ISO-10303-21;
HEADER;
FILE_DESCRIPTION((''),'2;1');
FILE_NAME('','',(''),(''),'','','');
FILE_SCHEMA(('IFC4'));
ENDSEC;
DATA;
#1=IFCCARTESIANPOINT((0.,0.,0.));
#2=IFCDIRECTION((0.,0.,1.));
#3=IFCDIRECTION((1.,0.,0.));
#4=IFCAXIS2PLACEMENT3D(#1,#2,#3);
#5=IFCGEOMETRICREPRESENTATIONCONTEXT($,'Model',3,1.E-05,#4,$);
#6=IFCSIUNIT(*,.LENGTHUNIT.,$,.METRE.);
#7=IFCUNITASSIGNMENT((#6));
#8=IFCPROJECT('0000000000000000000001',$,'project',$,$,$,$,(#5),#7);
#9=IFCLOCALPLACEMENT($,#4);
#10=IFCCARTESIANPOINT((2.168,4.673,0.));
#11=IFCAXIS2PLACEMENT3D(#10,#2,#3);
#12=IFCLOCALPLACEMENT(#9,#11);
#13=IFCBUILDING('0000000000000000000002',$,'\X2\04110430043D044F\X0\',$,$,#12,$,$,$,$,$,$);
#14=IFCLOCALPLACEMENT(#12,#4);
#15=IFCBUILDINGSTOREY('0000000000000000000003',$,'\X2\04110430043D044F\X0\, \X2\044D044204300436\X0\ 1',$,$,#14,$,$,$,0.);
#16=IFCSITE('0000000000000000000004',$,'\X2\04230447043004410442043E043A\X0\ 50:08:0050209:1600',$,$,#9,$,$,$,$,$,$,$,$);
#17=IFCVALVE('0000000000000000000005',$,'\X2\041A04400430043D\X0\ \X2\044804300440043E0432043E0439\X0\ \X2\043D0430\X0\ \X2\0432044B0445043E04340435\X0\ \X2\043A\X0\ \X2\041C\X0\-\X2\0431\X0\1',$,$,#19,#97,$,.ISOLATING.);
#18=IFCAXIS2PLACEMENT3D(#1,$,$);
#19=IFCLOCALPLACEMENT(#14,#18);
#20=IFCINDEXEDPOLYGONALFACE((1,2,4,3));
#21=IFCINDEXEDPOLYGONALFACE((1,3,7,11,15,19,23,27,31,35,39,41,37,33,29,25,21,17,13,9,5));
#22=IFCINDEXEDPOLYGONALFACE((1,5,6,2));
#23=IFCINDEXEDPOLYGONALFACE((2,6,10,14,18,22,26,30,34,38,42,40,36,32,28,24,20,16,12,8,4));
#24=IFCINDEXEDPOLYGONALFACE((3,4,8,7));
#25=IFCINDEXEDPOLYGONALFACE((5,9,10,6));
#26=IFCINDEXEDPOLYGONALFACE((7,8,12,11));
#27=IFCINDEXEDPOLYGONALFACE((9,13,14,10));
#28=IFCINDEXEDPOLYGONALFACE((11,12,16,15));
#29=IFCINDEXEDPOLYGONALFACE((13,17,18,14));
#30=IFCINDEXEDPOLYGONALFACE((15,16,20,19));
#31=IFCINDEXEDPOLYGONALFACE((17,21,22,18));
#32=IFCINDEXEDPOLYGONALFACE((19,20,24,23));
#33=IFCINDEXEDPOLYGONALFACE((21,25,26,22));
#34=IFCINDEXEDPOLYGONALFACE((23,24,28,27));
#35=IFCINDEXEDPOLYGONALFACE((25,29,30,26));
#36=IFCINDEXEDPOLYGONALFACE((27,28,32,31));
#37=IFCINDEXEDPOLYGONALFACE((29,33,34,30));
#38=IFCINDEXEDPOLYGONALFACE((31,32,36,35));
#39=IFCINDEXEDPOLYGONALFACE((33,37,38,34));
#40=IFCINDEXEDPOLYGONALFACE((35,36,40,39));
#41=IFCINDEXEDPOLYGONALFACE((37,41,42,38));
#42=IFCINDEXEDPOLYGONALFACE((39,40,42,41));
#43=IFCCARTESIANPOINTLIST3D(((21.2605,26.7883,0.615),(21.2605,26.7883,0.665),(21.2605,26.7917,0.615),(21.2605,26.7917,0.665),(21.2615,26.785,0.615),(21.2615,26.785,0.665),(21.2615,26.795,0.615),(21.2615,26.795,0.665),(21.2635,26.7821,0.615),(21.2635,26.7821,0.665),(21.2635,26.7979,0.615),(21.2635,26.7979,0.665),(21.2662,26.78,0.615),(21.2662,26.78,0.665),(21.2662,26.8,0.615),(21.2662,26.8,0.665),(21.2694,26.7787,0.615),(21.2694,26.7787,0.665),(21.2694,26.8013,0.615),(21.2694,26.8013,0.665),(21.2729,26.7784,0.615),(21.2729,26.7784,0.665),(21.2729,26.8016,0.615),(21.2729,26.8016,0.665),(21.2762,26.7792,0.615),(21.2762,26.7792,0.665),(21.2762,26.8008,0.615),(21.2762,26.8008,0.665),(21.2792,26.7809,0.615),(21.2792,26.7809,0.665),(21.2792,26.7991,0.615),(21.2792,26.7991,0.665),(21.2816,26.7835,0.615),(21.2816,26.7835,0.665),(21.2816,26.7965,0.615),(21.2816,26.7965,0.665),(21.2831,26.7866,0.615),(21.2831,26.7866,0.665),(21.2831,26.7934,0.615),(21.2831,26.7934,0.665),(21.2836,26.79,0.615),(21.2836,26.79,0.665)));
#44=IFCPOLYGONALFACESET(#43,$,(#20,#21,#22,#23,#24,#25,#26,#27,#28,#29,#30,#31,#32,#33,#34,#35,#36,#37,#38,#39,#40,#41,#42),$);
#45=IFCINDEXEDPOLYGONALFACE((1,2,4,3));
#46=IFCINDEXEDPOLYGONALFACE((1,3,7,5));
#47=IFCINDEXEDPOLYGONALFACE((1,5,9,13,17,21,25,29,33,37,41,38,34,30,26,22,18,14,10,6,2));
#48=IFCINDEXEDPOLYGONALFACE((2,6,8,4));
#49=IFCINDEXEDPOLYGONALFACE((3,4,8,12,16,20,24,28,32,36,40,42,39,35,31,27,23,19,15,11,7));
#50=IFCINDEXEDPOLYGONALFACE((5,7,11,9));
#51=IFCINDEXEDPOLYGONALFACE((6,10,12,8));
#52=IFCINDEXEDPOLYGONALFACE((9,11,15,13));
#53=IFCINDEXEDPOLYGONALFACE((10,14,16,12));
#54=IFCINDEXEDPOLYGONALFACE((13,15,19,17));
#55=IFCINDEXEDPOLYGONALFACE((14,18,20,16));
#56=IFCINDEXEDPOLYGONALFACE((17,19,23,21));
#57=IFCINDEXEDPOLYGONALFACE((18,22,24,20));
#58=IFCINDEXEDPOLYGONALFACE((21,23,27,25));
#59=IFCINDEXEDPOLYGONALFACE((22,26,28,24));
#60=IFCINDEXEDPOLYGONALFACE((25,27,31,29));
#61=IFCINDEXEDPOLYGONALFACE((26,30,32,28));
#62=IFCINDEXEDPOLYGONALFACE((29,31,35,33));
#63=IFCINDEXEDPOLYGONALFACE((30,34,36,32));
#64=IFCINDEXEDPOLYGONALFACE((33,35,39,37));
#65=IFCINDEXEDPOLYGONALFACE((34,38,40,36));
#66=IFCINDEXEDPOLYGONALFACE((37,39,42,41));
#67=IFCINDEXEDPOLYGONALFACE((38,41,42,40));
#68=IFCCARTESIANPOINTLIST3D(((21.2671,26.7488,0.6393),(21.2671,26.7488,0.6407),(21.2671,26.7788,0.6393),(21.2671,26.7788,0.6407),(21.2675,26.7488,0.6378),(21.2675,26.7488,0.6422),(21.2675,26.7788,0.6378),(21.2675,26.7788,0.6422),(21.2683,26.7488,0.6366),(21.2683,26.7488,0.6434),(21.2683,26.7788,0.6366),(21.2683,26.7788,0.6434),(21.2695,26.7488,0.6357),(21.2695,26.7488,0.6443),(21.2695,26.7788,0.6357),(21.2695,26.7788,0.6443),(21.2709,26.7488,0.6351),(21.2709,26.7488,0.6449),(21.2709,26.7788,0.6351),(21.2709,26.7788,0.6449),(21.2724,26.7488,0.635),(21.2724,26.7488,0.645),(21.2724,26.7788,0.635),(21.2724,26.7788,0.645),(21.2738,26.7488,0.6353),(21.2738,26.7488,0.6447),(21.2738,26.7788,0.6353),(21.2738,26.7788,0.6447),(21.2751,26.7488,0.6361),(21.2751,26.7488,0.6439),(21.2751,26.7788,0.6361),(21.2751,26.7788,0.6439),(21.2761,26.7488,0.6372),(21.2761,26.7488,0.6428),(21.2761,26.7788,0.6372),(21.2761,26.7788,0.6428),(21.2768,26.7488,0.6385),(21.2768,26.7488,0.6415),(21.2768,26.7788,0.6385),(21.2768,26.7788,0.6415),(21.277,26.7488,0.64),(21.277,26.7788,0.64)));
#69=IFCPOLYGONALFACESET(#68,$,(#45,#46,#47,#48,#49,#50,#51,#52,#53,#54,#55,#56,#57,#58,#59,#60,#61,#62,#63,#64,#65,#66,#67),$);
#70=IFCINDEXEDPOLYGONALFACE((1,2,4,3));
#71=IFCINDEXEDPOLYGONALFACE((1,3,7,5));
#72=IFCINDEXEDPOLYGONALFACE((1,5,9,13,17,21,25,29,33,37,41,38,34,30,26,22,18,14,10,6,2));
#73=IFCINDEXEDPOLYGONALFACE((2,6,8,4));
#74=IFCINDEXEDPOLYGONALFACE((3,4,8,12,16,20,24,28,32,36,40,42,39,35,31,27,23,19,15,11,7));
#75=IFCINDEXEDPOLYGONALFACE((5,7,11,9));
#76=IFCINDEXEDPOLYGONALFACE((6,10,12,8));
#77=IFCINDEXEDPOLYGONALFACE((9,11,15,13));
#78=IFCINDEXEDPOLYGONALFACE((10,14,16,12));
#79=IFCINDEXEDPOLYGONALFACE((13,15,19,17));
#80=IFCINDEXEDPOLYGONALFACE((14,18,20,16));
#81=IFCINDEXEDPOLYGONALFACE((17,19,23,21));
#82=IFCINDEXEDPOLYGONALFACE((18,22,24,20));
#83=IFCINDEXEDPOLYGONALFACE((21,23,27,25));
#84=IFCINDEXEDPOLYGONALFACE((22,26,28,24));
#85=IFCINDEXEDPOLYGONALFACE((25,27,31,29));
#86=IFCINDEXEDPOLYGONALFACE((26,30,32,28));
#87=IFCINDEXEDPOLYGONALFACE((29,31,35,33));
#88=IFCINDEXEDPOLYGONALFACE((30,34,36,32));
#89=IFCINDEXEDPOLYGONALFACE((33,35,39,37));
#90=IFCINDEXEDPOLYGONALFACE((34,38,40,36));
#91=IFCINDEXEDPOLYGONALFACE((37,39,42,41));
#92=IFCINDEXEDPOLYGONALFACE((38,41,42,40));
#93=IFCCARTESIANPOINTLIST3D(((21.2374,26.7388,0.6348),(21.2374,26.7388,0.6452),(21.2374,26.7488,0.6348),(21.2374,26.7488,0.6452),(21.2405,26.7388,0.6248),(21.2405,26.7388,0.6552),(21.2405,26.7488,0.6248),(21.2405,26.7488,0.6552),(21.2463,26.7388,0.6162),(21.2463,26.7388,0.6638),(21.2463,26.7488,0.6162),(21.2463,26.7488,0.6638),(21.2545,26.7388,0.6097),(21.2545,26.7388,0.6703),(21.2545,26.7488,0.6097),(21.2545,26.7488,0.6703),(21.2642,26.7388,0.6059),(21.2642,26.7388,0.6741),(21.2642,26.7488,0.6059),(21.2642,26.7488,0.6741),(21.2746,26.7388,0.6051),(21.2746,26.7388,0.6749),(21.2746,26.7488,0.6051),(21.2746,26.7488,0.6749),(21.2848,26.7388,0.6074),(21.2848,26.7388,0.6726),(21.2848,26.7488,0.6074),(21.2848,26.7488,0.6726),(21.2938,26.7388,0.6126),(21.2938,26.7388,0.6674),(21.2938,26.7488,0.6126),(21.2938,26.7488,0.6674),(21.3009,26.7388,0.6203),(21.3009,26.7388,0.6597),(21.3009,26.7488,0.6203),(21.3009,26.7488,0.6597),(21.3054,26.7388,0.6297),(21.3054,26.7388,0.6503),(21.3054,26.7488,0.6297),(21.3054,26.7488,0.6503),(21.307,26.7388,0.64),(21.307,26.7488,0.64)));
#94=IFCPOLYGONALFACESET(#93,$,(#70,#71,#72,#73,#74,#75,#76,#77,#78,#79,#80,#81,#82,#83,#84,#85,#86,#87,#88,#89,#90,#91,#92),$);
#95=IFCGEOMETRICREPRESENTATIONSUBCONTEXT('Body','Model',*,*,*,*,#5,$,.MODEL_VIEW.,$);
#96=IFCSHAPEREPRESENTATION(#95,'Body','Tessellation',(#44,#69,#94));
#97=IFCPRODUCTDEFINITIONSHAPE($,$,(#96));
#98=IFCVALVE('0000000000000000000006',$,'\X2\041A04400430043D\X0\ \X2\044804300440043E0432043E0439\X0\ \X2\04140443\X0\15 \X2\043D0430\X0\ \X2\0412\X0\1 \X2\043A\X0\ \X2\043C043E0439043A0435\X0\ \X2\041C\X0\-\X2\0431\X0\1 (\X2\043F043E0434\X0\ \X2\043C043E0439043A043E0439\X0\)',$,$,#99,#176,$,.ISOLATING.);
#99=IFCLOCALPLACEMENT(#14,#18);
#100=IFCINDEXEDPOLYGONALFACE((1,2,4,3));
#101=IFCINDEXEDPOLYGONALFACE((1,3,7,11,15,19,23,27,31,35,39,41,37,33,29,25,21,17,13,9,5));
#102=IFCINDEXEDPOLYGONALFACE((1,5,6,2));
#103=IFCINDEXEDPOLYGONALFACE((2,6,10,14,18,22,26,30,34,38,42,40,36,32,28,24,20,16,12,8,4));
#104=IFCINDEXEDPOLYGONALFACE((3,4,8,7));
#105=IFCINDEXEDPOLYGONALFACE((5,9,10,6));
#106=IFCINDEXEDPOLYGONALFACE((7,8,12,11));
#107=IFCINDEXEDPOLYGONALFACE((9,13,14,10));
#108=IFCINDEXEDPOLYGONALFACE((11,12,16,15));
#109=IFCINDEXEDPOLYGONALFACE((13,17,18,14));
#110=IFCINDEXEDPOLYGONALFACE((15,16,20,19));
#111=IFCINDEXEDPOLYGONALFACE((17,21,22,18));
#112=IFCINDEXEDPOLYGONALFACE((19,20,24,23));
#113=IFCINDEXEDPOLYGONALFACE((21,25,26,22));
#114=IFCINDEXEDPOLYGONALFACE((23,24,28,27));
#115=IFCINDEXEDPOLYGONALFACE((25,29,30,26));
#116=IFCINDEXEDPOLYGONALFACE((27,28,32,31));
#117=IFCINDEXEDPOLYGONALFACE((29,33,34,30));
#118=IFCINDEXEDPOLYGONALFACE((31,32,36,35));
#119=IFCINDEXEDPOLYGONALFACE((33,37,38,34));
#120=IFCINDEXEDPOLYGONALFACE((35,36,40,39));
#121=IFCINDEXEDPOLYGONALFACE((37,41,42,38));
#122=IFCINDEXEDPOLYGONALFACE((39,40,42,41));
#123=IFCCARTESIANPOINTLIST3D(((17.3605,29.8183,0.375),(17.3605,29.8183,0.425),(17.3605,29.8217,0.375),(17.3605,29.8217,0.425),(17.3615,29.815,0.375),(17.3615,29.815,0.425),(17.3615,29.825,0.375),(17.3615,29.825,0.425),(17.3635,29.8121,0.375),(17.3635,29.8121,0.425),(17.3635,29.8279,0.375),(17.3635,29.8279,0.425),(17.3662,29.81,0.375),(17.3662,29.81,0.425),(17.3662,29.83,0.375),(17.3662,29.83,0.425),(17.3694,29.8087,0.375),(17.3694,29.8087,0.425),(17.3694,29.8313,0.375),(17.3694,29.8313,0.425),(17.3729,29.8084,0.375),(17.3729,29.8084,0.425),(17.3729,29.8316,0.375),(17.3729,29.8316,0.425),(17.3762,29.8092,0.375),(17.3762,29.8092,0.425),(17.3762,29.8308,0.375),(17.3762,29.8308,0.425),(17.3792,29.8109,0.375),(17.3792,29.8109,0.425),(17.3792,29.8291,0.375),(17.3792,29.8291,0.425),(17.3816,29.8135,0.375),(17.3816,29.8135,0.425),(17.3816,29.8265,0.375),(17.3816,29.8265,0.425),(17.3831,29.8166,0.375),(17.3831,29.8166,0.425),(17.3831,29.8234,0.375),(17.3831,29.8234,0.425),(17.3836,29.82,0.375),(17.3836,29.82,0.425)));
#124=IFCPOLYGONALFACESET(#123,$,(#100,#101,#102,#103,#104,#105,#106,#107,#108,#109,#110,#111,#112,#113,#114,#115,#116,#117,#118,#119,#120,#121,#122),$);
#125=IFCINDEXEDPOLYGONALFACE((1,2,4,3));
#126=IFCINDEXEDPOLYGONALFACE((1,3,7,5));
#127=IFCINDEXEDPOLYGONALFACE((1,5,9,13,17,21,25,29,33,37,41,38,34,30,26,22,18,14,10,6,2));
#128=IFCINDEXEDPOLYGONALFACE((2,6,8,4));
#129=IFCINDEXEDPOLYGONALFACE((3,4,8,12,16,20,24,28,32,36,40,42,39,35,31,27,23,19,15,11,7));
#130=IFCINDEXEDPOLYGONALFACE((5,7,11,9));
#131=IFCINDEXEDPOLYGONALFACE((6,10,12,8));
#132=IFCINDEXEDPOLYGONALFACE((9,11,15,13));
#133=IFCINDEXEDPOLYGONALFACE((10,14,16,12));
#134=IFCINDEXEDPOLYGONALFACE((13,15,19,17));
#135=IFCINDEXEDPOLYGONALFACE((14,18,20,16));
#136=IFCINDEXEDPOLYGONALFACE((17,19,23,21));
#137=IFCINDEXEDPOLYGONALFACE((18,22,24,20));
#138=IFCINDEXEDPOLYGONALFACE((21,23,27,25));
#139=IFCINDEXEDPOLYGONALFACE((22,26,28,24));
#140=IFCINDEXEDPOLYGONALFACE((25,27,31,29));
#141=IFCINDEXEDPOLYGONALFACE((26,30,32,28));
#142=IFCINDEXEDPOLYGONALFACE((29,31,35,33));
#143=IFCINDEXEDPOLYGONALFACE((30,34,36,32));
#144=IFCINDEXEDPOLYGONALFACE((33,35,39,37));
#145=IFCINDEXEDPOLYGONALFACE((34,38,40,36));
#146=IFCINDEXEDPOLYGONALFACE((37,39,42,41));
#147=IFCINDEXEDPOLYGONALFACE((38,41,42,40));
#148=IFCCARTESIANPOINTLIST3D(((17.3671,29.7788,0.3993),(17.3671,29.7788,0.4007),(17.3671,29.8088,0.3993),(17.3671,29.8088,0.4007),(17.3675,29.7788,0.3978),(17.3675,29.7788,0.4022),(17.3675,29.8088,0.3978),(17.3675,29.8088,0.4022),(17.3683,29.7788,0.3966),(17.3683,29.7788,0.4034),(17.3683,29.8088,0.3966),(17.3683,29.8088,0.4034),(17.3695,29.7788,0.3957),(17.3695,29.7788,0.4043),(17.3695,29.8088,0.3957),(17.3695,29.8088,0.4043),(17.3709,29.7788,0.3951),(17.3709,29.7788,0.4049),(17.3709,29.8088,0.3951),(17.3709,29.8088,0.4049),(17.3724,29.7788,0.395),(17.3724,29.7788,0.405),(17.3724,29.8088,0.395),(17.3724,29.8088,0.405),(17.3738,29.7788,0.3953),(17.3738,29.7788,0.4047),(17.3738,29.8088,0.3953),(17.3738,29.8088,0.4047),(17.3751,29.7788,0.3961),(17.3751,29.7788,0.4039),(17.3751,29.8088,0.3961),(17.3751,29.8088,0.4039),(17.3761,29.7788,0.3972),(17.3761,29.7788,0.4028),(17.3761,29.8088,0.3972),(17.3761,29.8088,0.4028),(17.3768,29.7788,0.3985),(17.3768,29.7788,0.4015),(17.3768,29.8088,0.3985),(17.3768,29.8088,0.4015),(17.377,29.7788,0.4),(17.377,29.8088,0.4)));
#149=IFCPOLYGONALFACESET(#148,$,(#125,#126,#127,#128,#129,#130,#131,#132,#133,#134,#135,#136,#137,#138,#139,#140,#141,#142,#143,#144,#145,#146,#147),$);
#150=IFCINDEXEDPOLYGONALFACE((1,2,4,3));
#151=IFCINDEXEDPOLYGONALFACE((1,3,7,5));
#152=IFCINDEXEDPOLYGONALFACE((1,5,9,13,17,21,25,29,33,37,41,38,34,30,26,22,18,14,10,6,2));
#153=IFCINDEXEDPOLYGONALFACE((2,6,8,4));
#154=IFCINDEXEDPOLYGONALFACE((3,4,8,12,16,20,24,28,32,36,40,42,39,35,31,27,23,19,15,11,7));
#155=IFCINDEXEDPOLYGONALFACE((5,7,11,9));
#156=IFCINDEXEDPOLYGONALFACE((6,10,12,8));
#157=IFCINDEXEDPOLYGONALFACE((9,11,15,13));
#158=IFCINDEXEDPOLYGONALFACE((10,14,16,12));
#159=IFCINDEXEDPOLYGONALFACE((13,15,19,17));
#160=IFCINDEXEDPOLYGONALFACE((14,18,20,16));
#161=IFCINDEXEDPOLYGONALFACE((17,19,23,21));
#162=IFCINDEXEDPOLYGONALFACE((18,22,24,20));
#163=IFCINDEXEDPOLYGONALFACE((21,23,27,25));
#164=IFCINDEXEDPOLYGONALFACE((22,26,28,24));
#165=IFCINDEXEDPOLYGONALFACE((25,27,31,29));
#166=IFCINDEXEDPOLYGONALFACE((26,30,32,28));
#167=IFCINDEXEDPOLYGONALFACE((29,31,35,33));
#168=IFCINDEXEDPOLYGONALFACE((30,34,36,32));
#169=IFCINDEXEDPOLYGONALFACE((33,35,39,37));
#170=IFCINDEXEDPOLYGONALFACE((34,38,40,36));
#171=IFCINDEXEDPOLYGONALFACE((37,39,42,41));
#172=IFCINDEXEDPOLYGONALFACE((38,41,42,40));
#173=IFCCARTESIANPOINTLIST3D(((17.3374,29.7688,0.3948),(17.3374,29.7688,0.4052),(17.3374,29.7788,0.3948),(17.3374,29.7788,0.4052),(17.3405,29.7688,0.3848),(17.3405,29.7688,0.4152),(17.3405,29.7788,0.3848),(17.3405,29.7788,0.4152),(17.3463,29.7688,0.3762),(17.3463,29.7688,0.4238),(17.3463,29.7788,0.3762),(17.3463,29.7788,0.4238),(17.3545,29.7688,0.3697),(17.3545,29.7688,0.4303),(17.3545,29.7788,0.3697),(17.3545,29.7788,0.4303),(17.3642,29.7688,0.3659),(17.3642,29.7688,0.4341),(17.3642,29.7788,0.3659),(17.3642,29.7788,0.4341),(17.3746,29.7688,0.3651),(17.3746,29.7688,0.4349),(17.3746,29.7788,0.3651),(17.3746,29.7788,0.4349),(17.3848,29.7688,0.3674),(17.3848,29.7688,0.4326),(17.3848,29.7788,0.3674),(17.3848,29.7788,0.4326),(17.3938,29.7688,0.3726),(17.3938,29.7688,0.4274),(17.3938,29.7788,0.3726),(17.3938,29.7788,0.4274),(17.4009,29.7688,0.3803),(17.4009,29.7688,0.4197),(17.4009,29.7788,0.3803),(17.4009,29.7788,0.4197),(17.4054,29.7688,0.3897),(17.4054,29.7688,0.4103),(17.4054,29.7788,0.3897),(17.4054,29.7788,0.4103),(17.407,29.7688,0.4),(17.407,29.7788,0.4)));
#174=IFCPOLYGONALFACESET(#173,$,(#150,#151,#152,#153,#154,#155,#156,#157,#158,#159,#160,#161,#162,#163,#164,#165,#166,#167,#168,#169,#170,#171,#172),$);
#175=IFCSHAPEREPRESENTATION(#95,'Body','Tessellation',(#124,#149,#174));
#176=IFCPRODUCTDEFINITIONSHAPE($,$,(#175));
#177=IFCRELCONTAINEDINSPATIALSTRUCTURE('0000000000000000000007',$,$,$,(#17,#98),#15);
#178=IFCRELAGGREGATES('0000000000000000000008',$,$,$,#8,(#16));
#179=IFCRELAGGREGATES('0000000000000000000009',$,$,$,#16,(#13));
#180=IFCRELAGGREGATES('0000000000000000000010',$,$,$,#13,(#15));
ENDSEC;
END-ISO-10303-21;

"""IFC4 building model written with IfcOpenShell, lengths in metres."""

from ifc_helpers import new_model, si_unit, frame, origin_with_axes, origin_2d, place, context, subcontext, project, spatial, circle, extrude, element, save


model = new_model("IFC4")

# Units and contexts
model_context = context("Model", 3, precision=1e-05, world=origin_with_axes())
body_context = subcontext(model_context, "Body", "Model", "MODEL_VIEW")
ifc_project = project(units=[si_unit("LENGTHUNIT", "METRE")], contexts=[model_context])

# Site, building, storey
site_placement = place(None, origin_with_axes())
site = spatial("IfcSite", under=ifc_project, at=site_placement, Name="Участок 50:08:0050209:1600")
building_placement = place(site_placement, frame((2.168, 4.673, 0.0), z_axis=(0.0, 0.0, 1.0), x_axis=(1.0, 0.0, 0.0)))
building = spatial("IfcBuilding", under=site, at=building_placement, Name="Баня")
storey_placement = place(building_placement, origin_with_axes())
storey = spatial("IfcBuildingStorey", under=building, at=storey_placement, Name="Баня, этаж 1", Elevation=0.0)

# Valves
valve_1_placement = place(storey_placement, origin_with_axes())
element("IfcValve", 1, at=valve_1_placement, inside=storey, Name="Кран шаровой на выходе к М-б1", PredefinedType="ISOLATING", context=body_context, shape_type="SweptSolid", body=[
    extrude(circle(Radius=0.0116, at=origin_2d()), frame((21.272, 26.79, 0.615), z_axis=(0.0, 0.0, 1.0), x_axis=(1.0, 0.0, 0.0)), (0.0, 0.0, 1.0), 0.05),
    extrude(circle(Radius=0.005, at=origin_2d()), frame((21.272, 26.7788, 0.64), z_axis=(0.0, -1.0, 0.0), x_axis=(1.0, 0.0, 0.0)), (0.0, 0.0, 1.0), 0.03),
    extrude(circle(Radius=0.035, at=origin_2d()), frame((21.272, 26.7488, 0.64), z_axis=(0.0, -1.0, 0.0), x_axis=(1.0, 0.0, 0.0)), (0.0, 0.0, 1.0), 0.01),
])
valve_2_placement = place(storey_placement, origin_with_axes())
element("IfcValve", 2, at=valve_2_placement, inside=storey, Name="Кран шаровой Ду15 на В1 к мойке М-б1 (под мойкой)", PredefinedType="ISOLATING", context=body_context, shape_type="SweptSolid", body=[
    extrude(circle(Radius=0.0116, at=origin_2d()), frame((17.372, 29.82, 0.375), z_axis=(0.0, 0.0, 1.0), x_axis=(1.0, 0.0, 0.0)), (0.0, 0.0, 1.0), 0.05),
    extrude(circle(Radius=0.005, at=origin_2d()), frame((17.372, 29.8088, 0.4), z_axis=(0.0, -1.0, 0.0), x_axis=(1.0, 0.0, 0.0)), (0.0, 0.0, 1.0), 0.03),
    extrude(circle(Radius=0.035, at=origin_2d()), frame((17.372, 29.7788, 0.4), z_axis=(0.0, -1.0, 0.0), x_axis=(1.0, 0.0, 0.0)), (0.0, 0.0, 1.0), 0.01),
])

save(model, "model.ifc")
